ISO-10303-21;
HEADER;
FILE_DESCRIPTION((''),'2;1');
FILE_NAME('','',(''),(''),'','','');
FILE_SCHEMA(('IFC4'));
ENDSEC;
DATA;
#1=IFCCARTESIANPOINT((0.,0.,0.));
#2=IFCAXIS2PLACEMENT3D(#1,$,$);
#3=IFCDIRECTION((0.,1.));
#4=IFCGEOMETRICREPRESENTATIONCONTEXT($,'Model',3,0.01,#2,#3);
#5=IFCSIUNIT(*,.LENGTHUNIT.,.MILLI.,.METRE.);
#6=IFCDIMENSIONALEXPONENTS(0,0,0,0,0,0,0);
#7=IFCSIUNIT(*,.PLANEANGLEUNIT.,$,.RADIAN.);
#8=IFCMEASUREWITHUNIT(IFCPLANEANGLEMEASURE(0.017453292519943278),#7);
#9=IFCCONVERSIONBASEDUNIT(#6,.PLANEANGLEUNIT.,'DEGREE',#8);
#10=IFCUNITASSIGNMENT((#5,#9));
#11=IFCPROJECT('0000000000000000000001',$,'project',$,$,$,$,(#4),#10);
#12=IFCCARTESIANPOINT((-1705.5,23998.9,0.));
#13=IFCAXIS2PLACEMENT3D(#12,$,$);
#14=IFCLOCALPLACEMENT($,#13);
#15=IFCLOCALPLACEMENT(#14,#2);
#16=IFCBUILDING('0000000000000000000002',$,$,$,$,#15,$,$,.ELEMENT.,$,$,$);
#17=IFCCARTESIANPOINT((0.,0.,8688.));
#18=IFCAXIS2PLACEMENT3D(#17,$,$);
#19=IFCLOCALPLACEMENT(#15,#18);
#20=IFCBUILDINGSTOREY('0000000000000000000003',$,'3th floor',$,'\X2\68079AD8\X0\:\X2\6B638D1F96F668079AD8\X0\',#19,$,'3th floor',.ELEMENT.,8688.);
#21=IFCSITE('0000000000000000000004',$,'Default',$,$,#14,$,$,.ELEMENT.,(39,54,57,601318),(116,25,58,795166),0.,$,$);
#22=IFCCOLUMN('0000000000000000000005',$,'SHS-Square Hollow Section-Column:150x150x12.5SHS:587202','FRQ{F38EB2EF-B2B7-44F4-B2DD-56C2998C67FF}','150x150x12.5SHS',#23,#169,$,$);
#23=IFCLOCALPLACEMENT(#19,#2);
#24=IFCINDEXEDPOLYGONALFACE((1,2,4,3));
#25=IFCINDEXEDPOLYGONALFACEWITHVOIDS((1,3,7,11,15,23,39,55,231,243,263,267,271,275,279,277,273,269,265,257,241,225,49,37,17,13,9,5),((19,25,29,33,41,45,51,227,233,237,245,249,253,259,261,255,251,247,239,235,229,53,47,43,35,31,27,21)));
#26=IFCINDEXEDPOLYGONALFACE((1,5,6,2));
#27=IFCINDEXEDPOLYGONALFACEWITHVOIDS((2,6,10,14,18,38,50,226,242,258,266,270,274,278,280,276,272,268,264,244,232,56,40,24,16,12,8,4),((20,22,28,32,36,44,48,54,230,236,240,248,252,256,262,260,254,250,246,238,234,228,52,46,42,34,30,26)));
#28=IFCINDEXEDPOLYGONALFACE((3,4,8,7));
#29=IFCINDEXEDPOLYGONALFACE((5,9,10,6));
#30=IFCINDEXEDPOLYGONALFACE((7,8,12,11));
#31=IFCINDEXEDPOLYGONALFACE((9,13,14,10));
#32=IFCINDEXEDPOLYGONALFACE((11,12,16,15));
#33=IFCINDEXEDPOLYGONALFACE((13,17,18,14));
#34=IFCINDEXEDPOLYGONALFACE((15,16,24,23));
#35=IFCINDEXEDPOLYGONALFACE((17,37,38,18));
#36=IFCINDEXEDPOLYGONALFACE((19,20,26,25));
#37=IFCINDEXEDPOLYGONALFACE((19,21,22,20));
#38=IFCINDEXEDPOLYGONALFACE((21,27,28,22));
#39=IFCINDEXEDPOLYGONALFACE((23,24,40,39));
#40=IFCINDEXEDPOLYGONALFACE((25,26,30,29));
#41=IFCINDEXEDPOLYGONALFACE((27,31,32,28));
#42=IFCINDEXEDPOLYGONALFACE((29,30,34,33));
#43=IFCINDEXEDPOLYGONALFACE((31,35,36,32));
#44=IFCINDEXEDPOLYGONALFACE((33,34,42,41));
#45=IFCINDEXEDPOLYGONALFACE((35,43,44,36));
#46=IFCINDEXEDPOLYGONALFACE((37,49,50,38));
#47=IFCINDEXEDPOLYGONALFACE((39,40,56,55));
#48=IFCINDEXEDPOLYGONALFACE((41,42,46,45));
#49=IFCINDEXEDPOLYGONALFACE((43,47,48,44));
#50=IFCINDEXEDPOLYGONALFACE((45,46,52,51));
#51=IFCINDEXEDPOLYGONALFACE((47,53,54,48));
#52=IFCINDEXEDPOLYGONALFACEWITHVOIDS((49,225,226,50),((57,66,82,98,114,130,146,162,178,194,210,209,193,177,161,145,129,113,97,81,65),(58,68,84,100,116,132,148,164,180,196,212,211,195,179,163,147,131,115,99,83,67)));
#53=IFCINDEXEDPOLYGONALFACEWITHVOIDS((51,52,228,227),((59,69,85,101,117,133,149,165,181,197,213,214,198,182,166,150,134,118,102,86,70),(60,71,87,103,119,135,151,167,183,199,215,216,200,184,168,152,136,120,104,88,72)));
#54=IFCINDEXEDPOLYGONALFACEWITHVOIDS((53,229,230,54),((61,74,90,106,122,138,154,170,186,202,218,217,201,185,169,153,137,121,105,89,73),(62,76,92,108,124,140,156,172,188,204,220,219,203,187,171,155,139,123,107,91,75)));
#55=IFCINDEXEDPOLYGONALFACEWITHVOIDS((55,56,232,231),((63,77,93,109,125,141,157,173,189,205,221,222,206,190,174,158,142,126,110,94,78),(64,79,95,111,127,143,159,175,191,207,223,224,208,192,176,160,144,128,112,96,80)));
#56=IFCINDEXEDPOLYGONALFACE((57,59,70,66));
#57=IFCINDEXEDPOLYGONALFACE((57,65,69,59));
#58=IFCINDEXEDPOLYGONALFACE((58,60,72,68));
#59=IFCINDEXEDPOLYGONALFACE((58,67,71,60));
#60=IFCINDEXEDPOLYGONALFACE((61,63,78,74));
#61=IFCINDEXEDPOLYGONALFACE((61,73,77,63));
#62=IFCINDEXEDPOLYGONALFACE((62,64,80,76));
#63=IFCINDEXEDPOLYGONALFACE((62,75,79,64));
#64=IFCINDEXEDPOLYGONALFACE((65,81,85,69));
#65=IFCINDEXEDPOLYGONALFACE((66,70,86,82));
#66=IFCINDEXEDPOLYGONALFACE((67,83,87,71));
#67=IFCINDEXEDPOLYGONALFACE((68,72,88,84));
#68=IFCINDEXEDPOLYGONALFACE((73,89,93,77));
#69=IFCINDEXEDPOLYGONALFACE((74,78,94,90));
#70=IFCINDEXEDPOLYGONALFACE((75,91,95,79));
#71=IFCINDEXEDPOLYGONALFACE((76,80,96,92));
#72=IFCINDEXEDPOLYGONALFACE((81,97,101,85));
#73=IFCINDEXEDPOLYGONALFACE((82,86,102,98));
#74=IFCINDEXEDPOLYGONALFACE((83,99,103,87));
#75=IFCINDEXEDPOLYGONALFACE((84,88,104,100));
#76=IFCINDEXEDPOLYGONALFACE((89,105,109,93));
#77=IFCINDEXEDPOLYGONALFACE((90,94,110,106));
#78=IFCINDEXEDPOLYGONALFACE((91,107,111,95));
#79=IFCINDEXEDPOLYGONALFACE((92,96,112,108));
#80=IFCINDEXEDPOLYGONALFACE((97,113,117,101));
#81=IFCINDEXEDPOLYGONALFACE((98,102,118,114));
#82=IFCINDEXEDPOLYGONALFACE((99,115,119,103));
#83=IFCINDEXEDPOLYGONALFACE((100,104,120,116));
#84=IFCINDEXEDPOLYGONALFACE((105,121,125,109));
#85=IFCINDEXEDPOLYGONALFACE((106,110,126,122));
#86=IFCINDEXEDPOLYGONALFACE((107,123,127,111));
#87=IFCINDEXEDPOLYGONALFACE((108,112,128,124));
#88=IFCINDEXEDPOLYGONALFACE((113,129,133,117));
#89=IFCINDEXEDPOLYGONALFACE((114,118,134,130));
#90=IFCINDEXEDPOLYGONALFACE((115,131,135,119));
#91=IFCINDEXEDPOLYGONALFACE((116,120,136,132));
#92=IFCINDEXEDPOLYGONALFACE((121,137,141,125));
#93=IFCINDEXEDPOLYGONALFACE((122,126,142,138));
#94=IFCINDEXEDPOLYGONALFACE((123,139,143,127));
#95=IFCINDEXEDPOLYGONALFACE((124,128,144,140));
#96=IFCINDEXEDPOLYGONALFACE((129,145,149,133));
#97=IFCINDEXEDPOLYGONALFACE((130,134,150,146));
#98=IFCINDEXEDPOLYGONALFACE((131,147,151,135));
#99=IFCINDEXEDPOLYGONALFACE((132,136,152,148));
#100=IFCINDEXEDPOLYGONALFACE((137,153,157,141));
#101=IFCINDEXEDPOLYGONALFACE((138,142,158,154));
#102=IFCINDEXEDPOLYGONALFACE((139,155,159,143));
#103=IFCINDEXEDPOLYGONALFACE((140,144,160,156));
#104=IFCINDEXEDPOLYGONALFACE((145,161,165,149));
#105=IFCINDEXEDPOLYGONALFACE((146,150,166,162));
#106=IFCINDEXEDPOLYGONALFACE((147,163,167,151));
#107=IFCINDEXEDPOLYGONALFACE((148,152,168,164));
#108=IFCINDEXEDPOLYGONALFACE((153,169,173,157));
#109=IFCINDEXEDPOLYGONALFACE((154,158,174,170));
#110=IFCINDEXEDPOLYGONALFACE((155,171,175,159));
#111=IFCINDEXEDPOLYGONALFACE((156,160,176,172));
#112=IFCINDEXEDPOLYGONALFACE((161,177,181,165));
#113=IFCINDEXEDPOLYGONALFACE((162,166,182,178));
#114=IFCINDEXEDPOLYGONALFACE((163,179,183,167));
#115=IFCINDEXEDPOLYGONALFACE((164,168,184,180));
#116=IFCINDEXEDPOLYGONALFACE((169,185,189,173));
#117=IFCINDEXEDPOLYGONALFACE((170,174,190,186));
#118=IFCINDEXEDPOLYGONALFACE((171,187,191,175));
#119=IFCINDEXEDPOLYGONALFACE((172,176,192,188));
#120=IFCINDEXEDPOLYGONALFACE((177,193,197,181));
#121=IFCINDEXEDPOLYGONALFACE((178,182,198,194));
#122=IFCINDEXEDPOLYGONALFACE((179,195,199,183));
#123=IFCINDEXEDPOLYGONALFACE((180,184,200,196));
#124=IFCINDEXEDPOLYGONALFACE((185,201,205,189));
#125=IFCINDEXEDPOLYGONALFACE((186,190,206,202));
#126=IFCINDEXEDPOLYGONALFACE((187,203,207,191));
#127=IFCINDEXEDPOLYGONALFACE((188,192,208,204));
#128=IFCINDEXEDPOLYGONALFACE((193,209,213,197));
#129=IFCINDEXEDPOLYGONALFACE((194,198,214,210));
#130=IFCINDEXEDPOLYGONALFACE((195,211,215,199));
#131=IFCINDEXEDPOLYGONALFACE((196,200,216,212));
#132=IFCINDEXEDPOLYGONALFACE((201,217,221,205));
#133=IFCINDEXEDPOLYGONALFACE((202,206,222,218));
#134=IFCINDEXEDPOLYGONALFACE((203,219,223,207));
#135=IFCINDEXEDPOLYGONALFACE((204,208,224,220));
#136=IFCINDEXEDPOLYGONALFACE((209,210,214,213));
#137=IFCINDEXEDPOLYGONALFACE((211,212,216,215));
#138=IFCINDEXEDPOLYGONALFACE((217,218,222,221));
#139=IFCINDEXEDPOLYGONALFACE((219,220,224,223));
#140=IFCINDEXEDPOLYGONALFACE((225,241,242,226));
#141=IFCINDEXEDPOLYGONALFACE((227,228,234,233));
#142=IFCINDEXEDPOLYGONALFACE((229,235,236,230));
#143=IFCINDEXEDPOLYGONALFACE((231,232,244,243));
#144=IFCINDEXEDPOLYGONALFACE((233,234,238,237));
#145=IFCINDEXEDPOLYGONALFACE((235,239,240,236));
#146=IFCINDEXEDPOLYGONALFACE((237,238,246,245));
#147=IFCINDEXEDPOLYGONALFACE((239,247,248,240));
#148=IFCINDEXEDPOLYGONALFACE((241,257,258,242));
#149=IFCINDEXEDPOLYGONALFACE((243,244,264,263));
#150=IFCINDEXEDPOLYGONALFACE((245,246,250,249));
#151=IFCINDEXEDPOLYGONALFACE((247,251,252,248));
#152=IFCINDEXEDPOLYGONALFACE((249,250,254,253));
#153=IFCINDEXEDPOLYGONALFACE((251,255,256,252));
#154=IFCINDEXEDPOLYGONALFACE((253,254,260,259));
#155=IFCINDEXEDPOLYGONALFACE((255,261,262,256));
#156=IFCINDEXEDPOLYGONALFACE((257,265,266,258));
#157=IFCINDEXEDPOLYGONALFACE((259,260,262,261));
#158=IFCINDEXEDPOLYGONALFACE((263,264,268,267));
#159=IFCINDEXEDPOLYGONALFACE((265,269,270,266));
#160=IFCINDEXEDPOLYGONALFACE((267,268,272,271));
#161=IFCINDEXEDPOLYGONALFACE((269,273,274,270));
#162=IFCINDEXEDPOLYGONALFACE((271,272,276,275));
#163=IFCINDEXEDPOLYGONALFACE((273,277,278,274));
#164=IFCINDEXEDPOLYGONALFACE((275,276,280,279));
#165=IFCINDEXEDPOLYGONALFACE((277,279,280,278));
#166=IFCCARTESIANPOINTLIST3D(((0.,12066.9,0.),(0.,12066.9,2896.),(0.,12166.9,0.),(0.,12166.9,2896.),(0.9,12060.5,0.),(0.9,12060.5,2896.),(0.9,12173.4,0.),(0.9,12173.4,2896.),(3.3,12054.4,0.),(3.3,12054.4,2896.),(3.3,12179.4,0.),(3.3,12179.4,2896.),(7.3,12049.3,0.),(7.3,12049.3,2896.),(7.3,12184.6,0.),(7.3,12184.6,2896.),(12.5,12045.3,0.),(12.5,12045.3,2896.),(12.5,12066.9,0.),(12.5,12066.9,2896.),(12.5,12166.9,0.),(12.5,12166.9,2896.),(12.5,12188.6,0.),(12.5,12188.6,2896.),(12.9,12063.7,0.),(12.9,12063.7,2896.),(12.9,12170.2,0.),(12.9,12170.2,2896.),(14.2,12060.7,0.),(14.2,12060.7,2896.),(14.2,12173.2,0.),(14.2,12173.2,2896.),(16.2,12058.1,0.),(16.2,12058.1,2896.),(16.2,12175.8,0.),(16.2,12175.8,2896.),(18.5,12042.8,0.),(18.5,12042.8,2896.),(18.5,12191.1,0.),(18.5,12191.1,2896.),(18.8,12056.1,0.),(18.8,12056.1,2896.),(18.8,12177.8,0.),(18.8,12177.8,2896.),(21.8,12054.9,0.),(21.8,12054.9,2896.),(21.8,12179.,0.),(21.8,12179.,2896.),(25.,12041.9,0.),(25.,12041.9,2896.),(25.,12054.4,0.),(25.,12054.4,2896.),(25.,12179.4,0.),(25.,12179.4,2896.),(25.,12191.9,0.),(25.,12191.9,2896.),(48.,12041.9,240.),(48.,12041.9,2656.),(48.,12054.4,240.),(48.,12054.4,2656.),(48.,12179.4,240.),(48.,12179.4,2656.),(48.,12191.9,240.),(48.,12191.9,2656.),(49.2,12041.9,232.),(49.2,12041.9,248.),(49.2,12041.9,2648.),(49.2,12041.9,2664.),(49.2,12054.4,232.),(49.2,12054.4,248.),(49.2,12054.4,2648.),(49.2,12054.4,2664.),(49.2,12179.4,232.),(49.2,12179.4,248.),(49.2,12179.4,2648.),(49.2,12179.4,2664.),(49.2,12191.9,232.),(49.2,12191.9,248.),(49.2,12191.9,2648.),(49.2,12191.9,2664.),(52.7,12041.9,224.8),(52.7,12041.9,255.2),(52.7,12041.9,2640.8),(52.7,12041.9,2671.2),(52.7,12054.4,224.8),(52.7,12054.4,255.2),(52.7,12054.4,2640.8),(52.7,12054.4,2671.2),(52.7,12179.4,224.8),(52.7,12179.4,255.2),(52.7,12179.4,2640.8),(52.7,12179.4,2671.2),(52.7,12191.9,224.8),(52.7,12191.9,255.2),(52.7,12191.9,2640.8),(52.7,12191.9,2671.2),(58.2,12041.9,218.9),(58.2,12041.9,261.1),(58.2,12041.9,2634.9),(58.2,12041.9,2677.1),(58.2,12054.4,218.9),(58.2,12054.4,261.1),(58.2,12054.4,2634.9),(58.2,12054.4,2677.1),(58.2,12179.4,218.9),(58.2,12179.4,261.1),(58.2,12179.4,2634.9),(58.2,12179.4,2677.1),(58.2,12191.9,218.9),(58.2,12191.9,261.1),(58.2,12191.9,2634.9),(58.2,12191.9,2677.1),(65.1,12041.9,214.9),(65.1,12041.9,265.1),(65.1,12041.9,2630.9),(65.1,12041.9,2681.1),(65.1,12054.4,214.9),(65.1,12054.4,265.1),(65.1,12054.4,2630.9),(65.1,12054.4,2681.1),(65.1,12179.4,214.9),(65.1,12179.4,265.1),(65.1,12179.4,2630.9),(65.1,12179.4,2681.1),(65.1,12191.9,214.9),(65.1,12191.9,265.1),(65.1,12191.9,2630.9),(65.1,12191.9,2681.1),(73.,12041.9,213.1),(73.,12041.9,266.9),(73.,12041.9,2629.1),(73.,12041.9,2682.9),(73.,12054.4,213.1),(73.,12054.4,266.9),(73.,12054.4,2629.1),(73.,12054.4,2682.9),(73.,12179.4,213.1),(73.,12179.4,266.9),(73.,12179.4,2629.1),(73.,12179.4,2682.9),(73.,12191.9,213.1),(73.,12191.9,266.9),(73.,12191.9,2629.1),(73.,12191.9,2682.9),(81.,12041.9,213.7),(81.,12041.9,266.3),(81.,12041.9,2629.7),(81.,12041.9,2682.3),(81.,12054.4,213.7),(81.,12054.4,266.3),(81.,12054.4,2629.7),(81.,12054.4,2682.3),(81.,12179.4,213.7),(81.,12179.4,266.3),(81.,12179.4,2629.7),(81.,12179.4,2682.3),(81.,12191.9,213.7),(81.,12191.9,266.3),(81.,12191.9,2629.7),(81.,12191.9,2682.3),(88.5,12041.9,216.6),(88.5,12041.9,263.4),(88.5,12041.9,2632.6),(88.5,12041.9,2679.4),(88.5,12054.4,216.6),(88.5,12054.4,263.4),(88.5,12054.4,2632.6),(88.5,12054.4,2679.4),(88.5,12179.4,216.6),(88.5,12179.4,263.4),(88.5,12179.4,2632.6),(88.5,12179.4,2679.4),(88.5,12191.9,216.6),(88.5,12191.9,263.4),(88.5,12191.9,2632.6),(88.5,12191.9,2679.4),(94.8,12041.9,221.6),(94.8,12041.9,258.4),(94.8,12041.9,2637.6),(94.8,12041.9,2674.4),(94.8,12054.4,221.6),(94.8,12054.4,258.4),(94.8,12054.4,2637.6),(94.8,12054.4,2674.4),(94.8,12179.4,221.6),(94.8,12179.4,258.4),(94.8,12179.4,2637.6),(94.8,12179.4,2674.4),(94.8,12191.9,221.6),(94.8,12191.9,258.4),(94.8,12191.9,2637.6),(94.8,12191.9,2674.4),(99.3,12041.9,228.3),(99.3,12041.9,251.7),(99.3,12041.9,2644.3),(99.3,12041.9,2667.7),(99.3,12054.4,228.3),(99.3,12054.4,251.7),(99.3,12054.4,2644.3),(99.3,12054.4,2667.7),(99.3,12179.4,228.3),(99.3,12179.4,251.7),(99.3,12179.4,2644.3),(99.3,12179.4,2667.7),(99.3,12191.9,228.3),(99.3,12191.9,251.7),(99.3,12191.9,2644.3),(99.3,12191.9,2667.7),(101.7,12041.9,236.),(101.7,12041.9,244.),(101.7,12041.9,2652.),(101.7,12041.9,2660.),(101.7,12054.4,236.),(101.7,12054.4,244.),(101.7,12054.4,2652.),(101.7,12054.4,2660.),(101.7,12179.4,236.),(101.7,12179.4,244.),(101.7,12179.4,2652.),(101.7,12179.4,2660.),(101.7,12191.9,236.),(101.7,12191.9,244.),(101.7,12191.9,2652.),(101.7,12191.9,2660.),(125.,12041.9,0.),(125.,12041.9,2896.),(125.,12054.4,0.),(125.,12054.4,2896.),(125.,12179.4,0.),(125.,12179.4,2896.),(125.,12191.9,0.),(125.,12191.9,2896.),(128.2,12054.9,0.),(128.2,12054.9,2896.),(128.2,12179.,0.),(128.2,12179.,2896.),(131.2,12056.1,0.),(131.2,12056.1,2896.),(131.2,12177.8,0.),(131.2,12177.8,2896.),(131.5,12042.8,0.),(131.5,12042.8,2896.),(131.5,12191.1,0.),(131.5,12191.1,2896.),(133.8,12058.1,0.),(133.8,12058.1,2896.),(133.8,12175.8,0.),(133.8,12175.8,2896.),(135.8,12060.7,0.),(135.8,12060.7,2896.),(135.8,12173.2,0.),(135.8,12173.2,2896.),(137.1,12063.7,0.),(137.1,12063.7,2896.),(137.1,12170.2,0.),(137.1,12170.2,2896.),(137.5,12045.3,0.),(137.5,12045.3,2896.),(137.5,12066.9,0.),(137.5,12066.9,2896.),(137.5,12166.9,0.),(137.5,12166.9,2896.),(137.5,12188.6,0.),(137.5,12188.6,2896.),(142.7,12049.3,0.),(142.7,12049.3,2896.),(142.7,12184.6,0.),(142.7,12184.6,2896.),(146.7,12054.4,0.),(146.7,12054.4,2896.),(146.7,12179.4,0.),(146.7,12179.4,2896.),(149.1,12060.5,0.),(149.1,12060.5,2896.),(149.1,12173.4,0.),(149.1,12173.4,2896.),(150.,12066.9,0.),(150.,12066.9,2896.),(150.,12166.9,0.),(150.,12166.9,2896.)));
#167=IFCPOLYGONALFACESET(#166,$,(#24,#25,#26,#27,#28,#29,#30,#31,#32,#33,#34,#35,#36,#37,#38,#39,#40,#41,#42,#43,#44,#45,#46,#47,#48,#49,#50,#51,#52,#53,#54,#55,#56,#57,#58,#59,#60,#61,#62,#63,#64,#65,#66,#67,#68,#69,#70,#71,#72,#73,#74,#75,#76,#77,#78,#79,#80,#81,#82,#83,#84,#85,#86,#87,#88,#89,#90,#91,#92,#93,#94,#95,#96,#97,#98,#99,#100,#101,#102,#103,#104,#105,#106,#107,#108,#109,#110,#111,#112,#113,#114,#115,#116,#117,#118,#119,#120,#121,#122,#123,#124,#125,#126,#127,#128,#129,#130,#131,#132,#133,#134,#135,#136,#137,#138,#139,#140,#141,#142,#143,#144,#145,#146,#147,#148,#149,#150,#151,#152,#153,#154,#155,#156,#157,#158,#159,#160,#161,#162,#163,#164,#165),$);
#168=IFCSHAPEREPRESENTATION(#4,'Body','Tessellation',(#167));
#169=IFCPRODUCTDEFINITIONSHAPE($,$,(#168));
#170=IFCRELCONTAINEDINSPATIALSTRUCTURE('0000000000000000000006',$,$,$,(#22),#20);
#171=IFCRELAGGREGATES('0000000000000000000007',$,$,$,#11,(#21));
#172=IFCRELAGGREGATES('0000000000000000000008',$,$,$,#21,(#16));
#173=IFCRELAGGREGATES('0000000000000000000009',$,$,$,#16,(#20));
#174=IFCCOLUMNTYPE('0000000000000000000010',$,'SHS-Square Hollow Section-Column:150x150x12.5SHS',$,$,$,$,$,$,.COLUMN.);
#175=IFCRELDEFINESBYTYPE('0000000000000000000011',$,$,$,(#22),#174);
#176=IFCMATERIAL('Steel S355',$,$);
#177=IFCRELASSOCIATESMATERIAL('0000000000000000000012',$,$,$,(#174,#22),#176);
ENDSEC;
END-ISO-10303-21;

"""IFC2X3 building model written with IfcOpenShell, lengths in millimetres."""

from ifc_helpers import new_model, entity, si_unit, converted_unit, direction, frame, frame_2d, origin, origin_2d, place, context, project, spatial, circle_curve, hollow_rectangle, outline, extrude, material, type_object, element, save


model = new_model("IFC2X3")

# Units and contexts
model_context = context("Model", 3, precision=0.01, world=origin(), true_north=direction((0.0, 1.0)))
ifc_project = project(units=[si_unit("LENGTHUNIT", "METRE", prefix="MILLI"), converted_unit("PLANEANGLEUNIT", "DEGREE", entity("IfcPlaneAngleMeasure", 0.017453292519943278), si_unit("PLANEANGLEUNIT", "RADIAN"), dimensions=[0, 0, 0, 0, 0, 0, 0])], contexts=[model_context])

# Site, building, storey
site_placement = place(None, frame((-1705.5, 23998.9, 0.0)))
site = spatial("IfcSite", under=ifc_project, at=site_placement, Name="Default", CompositionType="ELEMENT", RefLatitude=(39, 54, 57, 601318), RefLongitude=(116, 25, 58, 795166), RefElevation=0.0)
building_placement = place(site_placement, origin())
building = spatial("IfcBuilding", under=site, at=building_placement, CompositionType="ELEMENT")
storey_placement = place(building_placement, frame((0.0, 0.0, 8688.0)))
storey = spatial("IfcBuildingStorey", under=building, at=storey_placement, Name="3th floor", ObjectType="标高:正负零标高", LongName="3th floor", CompositionType="ELEMENT", Elevation=8688.0)

# Shared definitions
ifc_material_1 = material(Name="Steel S355")

# Column, openings
column_type_1 = type_object("IfcColumnType", Name="SHS-Square Hollow Section-Column:150x150x12.5SHS", PredefinedType="COLUMN", material=ifc_material_1)
column_1_placement = place(storey_placement, frame((75.0, 12116.9, 2896.0), z_axis=(0.0, 0.0, 1.0), x_axis=(0.0, -1.0, 0.0)))
column_1 = element("IfcColumn", 1, at=column_1_placement, inside=storey, type_object=column_type_1, material=ifc_material_1, Name="SHS-Square Hollow Section-Column:150x150x12.5SHS:587202", Description="FRQ{F38EB2EF-B2B7-44F4-B2DD-56C2998C67FF}", ObjectType="150x150x12.5SHS", context=model_context, shape_type="SweptSolid", body=[
    extrude(hollow_rectangle(XDim=150.0, YDim=150.0, WallThickness=12.5, InnerFilletRadius=12.5, OuterFilletRadius=25.0, at=origin_2d()), origin(), (0.0, 0.0, -1.0), 2896.0),
])
opening_1_placement = place(column_1_placement, frame((175.1, 0.0, 0.0), z_axis=(-1.0, 0.0, 0.0), x_axis=(0.0, -1.0, 0.0)))
element("IfcOpeningElement", 2, at=opening_1_placement, cuts=column_1, ObjectType="Opening", context=model_context, shape_type="SweptSolid", body=[
    extrude(outline(circle_curve(frame_2d((0.0, -240.0), x_axis=(1.0, 0.0)), 27.0)), origin(), (0.0, 0.0, 1.0), 350.2),
])
opening_2_placement = place(column_1_placement, frame((175.1, 0.0, -2896.0), z_axis=(-1.0, 0.0, 0.0), x_axis=(0.0, -1.0, 0.0)))
element("IfcOpeningElement", 3, at=opening_2_placement, cuts=column_1, ObjectType="Opening", context=model_context, shape_type="SweptSolid", body=[
    extrude(outline(circle_curve(frame_2d((0.0, 240.0), x_axis=(1.0, 0.0)), 27.0)), origin(), (0.0, 0.0, 1.0), 350.2),
])

save(model, "model.ifc")
